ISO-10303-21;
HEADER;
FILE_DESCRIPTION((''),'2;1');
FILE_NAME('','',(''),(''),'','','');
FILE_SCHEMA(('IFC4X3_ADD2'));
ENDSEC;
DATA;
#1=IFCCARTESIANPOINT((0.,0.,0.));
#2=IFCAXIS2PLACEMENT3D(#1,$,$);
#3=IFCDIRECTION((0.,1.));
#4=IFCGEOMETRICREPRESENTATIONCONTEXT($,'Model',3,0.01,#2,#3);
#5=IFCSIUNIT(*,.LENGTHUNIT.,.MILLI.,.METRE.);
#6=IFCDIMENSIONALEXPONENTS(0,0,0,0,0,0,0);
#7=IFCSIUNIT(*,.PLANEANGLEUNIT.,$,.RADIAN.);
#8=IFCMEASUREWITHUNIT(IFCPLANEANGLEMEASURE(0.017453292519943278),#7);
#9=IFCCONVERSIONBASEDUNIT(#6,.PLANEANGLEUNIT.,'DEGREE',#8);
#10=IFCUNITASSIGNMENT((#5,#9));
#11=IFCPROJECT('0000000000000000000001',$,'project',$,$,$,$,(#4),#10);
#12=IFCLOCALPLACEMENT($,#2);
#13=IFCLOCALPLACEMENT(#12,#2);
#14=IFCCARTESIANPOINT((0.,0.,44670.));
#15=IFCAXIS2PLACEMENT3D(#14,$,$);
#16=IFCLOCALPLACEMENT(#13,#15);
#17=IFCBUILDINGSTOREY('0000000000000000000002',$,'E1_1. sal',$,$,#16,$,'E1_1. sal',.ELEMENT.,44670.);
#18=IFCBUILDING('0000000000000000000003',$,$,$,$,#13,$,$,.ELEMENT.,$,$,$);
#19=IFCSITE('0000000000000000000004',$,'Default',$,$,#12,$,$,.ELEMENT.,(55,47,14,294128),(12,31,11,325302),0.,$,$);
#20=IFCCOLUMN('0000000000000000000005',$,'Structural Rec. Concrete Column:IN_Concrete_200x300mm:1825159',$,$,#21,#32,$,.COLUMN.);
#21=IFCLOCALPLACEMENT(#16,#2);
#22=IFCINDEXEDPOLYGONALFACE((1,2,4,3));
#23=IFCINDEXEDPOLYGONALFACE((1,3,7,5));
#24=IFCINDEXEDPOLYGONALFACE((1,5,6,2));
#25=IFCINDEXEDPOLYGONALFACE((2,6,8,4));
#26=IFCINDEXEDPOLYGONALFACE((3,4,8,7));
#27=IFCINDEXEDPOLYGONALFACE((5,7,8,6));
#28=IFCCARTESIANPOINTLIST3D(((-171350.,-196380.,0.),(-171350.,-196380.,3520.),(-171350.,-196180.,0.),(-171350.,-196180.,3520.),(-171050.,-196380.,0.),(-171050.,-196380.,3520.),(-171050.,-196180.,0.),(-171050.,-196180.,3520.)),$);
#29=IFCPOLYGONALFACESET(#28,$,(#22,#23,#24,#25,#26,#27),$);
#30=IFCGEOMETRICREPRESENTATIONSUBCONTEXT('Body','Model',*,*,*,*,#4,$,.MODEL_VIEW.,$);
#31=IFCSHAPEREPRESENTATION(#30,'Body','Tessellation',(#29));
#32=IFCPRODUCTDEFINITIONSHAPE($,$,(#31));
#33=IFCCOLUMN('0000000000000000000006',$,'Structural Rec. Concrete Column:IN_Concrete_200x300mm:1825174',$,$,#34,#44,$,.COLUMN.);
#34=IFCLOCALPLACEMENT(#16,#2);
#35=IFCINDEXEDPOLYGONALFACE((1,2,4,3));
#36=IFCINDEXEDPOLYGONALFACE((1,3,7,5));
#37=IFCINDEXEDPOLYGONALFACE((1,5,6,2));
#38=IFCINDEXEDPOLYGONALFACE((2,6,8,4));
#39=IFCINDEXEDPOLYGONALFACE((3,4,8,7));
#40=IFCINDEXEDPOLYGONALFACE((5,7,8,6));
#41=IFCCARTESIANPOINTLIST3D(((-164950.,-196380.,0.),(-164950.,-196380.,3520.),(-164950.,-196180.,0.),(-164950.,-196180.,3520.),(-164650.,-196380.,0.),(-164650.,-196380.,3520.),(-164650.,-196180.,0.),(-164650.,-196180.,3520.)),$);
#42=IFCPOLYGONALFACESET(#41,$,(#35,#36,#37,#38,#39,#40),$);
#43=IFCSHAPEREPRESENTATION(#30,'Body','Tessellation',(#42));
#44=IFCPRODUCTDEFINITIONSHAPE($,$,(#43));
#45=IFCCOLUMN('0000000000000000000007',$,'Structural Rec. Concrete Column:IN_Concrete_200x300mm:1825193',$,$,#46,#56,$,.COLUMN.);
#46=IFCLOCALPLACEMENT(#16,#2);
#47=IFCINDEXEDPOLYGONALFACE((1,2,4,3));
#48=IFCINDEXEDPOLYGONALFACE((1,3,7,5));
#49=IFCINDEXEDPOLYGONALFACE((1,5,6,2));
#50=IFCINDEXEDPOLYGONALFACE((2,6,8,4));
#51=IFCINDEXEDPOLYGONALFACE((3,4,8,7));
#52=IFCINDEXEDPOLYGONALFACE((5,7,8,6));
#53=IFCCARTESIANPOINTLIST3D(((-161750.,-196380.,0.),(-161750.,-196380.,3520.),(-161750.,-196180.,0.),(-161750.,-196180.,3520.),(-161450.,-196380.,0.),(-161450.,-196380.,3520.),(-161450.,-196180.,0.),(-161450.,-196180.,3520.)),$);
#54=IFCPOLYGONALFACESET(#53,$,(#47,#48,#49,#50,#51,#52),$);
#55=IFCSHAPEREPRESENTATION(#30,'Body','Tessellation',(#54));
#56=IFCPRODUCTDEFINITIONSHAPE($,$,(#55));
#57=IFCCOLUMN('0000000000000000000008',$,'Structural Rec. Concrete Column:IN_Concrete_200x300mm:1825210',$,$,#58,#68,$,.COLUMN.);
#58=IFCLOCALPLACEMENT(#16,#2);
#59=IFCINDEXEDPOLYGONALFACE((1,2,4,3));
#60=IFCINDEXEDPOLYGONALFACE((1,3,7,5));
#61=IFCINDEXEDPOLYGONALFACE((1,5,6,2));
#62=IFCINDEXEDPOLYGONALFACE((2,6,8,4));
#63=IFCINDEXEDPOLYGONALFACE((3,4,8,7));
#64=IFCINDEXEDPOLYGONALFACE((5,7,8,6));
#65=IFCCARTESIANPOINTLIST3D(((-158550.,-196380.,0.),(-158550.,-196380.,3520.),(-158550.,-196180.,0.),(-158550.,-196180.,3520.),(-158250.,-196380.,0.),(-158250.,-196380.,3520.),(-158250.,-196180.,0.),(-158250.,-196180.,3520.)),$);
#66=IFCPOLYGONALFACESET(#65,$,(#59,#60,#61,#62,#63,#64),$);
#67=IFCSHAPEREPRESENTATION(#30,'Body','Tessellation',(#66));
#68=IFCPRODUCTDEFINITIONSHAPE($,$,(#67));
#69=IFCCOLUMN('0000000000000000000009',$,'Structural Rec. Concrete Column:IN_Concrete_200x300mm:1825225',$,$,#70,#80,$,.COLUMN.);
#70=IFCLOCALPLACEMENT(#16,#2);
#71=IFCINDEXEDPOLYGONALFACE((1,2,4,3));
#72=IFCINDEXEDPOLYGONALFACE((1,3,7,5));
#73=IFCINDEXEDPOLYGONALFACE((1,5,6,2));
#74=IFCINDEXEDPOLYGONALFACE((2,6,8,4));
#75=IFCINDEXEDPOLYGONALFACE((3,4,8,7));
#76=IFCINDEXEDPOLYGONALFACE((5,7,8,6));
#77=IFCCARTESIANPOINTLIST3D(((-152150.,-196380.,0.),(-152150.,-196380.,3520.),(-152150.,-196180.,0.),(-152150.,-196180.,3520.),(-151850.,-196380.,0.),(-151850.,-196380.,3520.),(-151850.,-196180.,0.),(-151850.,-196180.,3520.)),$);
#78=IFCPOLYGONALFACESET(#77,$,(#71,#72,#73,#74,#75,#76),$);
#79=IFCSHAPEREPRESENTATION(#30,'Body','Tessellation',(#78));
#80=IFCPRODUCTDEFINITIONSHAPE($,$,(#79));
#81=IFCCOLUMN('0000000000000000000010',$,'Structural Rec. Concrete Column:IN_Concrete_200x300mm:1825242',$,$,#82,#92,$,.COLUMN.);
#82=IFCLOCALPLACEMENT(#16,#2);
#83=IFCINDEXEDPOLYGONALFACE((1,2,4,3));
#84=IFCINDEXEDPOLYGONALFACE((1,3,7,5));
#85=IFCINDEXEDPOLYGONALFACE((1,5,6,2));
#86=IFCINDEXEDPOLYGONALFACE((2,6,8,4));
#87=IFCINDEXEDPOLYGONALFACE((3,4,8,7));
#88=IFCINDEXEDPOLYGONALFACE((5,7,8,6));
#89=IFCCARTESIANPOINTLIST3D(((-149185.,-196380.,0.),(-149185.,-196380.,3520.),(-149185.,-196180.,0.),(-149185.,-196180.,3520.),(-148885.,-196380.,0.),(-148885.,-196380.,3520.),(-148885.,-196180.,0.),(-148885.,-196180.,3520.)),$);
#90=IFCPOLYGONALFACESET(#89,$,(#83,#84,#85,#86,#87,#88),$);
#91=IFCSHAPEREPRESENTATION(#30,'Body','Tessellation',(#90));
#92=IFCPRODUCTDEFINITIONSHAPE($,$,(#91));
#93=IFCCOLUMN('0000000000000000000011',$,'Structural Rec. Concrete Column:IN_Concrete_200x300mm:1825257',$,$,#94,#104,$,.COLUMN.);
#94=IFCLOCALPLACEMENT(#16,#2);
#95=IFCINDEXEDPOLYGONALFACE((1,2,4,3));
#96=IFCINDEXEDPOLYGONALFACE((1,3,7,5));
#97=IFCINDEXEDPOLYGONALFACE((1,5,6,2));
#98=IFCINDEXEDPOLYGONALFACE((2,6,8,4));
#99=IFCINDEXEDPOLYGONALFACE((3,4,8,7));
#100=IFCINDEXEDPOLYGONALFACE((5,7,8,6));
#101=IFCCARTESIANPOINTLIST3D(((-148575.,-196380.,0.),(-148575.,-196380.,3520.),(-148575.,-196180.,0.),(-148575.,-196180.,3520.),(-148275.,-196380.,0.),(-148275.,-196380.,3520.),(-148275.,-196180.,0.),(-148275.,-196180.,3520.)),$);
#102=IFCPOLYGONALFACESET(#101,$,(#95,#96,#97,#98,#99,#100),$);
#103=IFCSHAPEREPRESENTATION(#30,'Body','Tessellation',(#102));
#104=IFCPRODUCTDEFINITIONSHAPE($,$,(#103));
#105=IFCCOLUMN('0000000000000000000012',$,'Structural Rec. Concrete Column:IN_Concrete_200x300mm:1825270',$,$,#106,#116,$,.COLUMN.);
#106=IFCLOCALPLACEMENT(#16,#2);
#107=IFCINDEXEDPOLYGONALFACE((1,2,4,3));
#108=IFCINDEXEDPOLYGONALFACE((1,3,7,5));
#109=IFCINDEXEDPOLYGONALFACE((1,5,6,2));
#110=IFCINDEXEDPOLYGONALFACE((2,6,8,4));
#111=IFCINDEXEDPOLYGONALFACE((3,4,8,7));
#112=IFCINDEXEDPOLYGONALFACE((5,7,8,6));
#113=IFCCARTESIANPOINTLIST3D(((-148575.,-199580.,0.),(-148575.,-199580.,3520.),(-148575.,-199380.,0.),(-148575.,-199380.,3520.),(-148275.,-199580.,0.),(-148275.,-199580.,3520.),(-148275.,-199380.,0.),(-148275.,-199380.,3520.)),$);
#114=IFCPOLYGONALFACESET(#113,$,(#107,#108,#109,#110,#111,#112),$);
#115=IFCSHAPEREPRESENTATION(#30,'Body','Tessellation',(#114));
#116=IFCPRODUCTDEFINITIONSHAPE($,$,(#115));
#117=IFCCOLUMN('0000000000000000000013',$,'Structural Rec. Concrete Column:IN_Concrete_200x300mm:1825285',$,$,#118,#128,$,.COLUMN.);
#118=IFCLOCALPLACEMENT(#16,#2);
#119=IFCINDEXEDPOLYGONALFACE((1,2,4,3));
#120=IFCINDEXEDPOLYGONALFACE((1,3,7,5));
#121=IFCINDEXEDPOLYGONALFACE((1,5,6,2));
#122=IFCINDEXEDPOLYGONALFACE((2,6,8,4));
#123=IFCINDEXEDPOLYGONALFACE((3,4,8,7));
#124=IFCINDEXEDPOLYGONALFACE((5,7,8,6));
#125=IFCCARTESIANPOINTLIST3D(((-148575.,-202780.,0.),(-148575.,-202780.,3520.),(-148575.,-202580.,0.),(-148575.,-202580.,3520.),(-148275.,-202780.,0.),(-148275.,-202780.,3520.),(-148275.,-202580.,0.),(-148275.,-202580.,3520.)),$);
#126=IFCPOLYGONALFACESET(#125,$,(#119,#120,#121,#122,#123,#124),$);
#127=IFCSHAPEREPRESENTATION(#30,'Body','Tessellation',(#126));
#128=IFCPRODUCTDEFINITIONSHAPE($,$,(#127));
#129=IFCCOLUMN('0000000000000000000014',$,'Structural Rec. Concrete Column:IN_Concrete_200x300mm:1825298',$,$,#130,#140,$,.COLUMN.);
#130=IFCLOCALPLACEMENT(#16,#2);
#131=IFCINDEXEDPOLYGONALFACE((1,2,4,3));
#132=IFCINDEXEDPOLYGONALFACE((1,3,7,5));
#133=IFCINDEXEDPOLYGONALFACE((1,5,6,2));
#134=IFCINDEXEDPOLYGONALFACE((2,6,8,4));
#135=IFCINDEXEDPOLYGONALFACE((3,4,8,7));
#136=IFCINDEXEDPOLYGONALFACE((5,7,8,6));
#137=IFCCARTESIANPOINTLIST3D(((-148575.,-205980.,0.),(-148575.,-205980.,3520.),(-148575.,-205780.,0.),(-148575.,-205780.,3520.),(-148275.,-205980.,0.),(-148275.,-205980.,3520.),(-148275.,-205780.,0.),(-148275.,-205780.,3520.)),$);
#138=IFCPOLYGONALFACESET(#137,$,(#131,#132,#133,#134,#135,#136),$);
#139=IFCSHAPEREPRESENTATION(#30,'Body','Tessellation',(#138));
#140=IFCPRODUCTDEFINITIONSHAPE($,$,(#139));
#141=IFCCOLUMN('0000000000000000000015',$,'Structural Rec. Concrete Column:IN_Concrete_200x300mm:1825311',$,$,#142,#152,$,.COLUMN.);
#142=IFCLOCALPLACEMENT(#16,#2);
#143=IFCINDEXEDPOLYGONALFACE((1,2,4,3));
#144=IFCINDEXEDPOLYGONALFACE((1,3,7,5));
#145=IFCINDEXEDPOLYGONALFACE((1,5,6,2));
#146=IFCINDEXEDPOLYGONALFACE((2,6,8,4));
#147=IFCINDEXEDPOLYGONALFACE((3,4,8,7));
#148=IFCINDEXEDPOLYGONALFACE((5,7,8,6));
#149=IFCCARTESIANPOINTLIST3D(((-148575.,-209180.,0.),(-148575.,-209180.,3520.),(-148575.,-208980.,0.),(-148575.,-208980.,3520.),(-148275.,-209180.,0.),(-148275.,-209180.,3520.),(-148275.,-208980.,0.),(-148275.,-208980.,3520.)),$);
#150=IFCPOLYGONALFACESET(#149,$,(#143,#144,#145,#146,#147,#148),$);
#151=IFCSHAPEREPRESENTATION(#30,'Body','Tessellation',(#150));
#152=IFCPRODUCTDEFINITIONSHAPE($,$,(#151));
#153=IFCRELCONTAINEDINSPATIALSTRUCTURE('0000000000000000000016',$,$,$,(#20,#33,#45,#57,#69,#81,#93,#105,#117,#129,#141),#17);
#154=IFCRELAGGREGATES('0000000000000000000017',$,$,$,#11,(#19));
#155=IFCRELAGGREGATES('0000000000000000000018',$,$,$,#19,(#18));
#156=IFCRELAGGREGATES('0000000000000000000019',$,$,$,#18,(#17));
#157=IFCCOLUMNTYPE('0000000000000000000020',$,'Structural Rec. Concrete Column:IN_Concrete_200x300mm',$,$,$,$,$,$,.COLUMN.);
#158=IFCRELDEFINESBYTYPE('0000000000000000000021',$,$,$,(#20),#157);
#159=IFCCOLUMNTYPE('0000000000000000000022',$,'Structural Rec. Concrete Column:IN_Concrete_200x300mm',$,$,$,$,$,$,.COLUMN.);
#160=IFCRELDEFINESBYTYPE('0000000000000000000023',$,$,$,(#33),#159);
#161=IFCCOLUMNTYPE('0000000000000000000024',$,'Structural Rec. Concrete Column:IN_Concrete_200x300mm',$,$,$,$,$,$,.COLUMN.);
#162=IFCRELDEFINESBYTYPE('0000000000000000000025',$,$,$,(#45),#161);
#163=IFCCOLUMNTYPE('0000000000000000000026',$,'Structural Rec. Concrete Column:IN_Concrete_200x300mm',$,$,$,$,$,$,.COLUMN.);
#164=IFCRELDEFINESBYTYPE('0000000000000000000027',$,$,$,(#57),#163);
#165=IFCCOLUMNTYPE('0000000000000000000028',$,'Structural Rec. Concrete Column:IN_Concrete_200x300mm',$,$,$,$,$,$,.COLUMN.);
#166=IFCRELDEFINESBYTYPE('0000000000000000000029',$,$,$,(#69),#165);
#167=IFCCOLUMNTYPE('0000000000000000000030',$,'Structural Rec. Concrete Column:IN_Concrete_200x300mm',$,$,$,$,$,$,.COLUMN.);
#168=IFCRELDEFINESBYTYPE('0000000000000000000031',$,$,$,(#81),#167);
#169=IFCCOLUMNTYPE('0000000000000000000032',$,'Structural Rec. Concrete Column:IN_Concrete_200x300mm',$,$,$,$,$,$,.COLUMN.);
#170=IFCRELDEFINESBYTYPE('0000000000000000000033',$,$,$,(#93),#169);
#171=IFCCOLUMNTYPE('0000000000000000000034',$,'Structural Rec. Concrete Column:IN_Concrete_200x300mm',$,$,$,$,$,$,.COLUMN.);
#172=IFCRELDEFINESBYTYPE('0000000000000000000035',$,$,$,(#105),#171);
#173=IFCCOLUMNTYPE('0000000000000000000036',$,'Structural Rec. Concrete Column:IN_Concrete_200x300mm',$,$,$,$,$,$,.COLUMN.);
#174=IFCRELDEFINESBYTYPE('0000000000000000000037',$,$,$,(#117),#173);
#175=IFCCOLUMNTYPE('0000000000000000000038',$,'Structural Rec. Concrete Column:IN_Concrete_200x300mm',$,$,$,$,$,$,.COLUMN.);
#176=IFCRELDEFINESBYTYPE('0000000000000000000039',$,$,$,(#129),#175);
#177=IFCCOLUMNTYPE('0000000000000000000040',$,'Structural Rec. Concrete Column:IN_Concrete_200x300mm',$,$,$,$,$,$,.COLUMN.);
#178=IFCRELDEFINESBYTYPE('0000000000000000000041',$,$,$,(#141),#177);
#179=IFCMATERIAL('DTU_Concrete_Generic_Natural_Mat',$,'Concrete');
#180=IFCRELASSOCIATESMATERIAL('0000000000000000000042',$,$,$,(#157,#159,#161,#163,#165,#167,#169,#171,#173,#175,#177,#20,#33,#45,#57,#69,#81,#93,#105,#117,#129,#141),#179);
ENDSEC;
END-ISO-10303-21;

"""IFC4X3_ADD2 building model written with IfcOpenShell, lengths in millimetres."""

from ifc_helpers import new_model, entity, si_unit, converted_unit, direction, frame, frame_2d, origin, place, context, subcontext, project, spatial, rectangle, extrude, source, transform, mapped, material, material_profile, profile_set, profile_usage, type_object, type_shapes, element, save


model = new_model("IFC4X3_ADD2")

# Units and contexts
model_context = context("Model", 3, precision=0.01, world=origin(), true_north=direction((0.0, 1.0)))
body_context = subcontext(model_context, "Body", "Model", "MODEL_VIEW")
ifc_project = project(units=[si_unit("LENGTHUNIT", "METRE", prefix="MILLI"), converted_unit("PLANEANGLEUNIT", "DEGREE", entity("IfcPlaneAngleMeasure", 0.017453292519943278), si_unit("PLANEANGLEUNIT", "RADIAN"), dimensions=[0, 0, 0, 0, 0, 0, 0])], contexts=[model_context])

# Site, building, storey
site_placement = place(None, origin())
site = spatial("IfcSite", under=ifc_project, at=site_placement, Name="Default", CompositionType="ELEMENT", RefLatitude=(55, 47, 14, 294128), RefLongitude=(12, 31, 11, 325302), RefElevation=0.0)
building_placement = place(site_placement, origin())
building = spatial("IfcBuilding", under=site, at=building_placement, CompositionType="ELEMENT")
storey_placement = place(building_placement, frame((0.0, 0.0, 44670.0)))
storey = spatial("IfcBuildingStorey", under=building, at=storey_placement, Name="E1_1. sal", LongName="E1_1. sal", CompositionType="ELEMENT", Elevation=44670.0)

# Columns
ifc_material = material(Name="DTU_Concrete_Generic_Natural_Mat", Category="Concrete")
ifc_material_profile_1 = material_profile(ifc_material, rectangle(XDim=200.0, YDim=300.0, at=frame_2d((0.0, 0.0), x_axis=(1.0, 0.0))), Name="IN_Concrete_200x300mm")
ifc_profile_set_1 = profile_set([ifc_material_profile_1], Name="IN_Concrete_200x300mm")
ifc_profile_usage_1 = profile_usage(ifc_profile_set_1)
column_type_1 = type_object("IfcColumnType", Name="Structural Rec. Concrete Column:IN_Concrete_200x300mm", PredefinedType="COLUMN", material=ifc_profile_set_1)
shared_shape_1 = source(origin(), body_context, "Body", "SweptSolid", [
    extrude(rectangle(XDim=200.0, YDim=300.0, at=frame_2d((0.0, 0.0), x_axis=(1.0, 0.0))), frame((-171200.0, -196280.0, 44670.0), z_axis=(0.0, 0.0, 1.0), x_axis=(0.0, -1.0, 0.0)), (0.0, 0.0, 1.0), 3520.0),
])
type_shapes(column_type_1, [shared_shape_1])
column_1_placement = place(storey_placement, frame((0.0, 0.0, -44670.0)))
element("IfcColumn", 1, at=column_1_placement, inside=storey, type_object=column_type_1, material=ifc_profile_usage_1, Name="Structural Rec. Concrete Column:IN_Concrete_200x300mm:1825159", PredefinedType="COLUMN", context=body_context, shape_type="MappedRepresentation", body=[
    mapped(shared_shape_1, transform((0.0, 0.0, 0.0), scale=1.0)),
])
column_type_2 = type_object("IfcColumnType", Name="Structural Rec. Concrete Column:IN_Concrete_200x300mm", PredefinedType="COLUMN", material=ifc_profile_set_1)
shared_shape_2 = source(origin(), body_context, "Body", "SweptSolid", [
    extrude(rectangle(XDim=200.0, YDim=300.0, at=frame_2d((0.0, 0.0), x_axis=(1.0, 0.0))), frame((-164800.0, -196280.0, 44670.0), z_axis=(0.0, 0.0, 1.0), x_axis=(0.0, -1.0, 0.0)), (0.0, 0.0, 1.0), 3520.0),
])
type_shapes(column_type_2, [shared_shape_2])
column_2_placement = place(storey_placement, frame((0.0, 0.0, -44670.0)))
element("IfcColumn", 2, at=column_2_placement, inside=storey, type_object=column_type_2, material=ifc_profile_usage_1, Name="Structural Rec. Concrete Column:IN_Concrete_200x300mm:1825174", PredefinedType="COLUMN", context=body_context, shape_type="MappedRepresentation", body=[
    mapped(shared_shape_2, transform((0.0, 0.0, 0.0), scale=1.0)),
])
column_type_3 = type_object("IfcColumnType", Name="Structural Rec. Concrete Column:IN_Concrete_200x300mm", PredefinedType="COLUMN", material=ifc_profile_set_1)
shared_shape_3 = source(origin(), body_context, "Body", "SweptSolid", [
    extrude(rectangle(XDim=200.0, YDim=300.0, at=frame_2d((0.0, 0.0), x_axis=(1.0, 0.0))), frame((-161600.0, -196280.0, 44670.0), z_axis=(0.0, 0.0, 1.0), x_axis=(0.0, -1.0, 0.0)), (0.0, 0.0, 1.0), 3520.0),
])
type_shapes(column_type_3, [shared_shape_3])
column_3_placement = place(storey_placement, frame((0.0, 0.0, -44670.0)))
element("IfcColumn", 3, at=column_3_placement, inside=storey, type_object=column_type_3, material=ifc_profile_usage_1, Name="Structural Rec. Concrete Column:IN_Concrete_200x300mm:1825193", PredefinedType="COLUMN", context=body_context, shape_type="MappedRepresentation", body=[
    mapped(shared_shape_3, transform((0.0, 0.0, 0.0), scale=1.0)),
])
column_type_4 = type_object("IfcColumnType", Name="Structural Rec. Concrete Column:IN_Concrete_200x300mm", PredefinedType="COLUMN", material=ifc_profile_set_1)
shared_shape_4 = source(origin(), body_context, "Body", "SweptSolid", [
    extrude(rectangle(XDim=200.0, YDim=300.0, at=frame_2d((0.0, 0.0), x_axis=(1.0, 0.0))), frame((-158400.0, -196280.0, 44670.0), z_axis=(0.0, 0.0, 1.0), x_axis=(0.0, -1.0, 0.0)), (0.0, 0.0, 1.0), 3520.0),
])
type_shapes(column_type_4, [shared_shape_4])
column_4_placement = place(storey_placement, frame((0.0, 0.0, -44670.0)))
element("IfcColumn", 4, at=column_4_placement, inside=storey, type_object=column_type_4, material=ifc_profile_usage_1, Name="Structural Rec. Concrete Column:IN_Concrete_200x300mm:1825210", PredefinedType="COLUMN", context=body_context, shape_type="MappedRepresentation", body=[
    mapped(shared_shape_4, transform((0.0, 0.0, 0.0), scale=1.0)),
])
column_type_5 = type_object("IfcColumnType", Name="Structural Rec. Concrete Column:IN_Concrete_200x300mm", PredefinedType="COLUMN", material=ifc_profile_set_1)
shared_shape_5 = source(origin(), body_context, "Body", "SweptSolid", [
    extrude(rectangle(XDim=200.0, YDim=300.0, at=frame_2d((0.0, 0.0), x_axis=(1.0, 0.0))), frame((-152000.0, -196280.0, 44670.0), z_axis=(0.0, 0.0, 1.0), x_axis=(0.0, -1.0, 0.0)), (0.0, 0.0, 1.0), 3520.0),
])
type_shapes(column_type_5, [shared_shape_5])
column_5_placement = place(storey_placement, frame((0.0, 0.0, -44670.0)))
element("IfcColumn", 5, at=column_5_placement, inside=storey, type_object=column_type_5, material=ifc_profile_usage_1, Name="Structural Rec. Concrete Column:IN_Concrete_200x300mm:1825225", PredefinedType="COLUMN", context=body_context, shape_type="MappedRepresentation", body=[
    mapped(shared_shape_5, transform((0.0, 0.0, 0.0), scale=1.0)),
])
column_type_6 = type_object("IfcColumnType", Name="Structural Rec. Concrete Column:IN_Concrete_200x300mm", PredefinedType="COLUMN", material=ifc_profile_set_1)
shared_shape_6 = source(origin(), body_context, "Body", "SweptSolid", [
    extrude(rectangle(XDim=200.0, YDim=300.0, at=frame_2d((0.0, 0.0), x_axis=(1.0, 0.0))), frame((-149035.0, -196280.0, 44670.0), z_axis=(0.0, 0.0, 1.0), x_axis=(0.0, -1.0, 0.0)), (0.0, 0.0, 1.0), 3520.0),
])
type_shapes(column_type_6, [shared_shape_6])
column_6_placement = place(storey_placement, frame((0.0, 0.0, -44670.0)))
element("IfcColumn", 6, at=column_6_placement, inside=storey, type_object=column_type_6, material=ifc_profile_usage_1, Name="Structural Rec. Concrete Column:IN_Concrete_200x300mm:1825242", PredefinedType="COLUMN", context=body_context, shape_type="MappedRepresentation", body=[
    mapped(shared_shape_6, transform((0.0, 0.0, 0.0), scale=1.0)),
])
column_type_7 = type_object("IfcColumnType", Name="Structural Rec. Concrete Column:IN_Concrete_200x300mm", PredefinedType="COLUMN", material=ifc_profile_set_1)
shared_shape_7 = source(origin(), body_context, "Body", "SweptSolid", [
    extrude(rectangle(XDim=200.0, YDim=300.0, at=frame_2d((0.0, 0.0), x_axis=(1.0, 0.0))), frame((-148425.0, -196280.0, 44670.0), z_axis=(0.0, 0.0, 1.0), x_axis=(0.0, -1.0, 0.0)), (0.0, 0.0, 1.0), 3520.0),
])
type_shapes(column_type_7, [shared_shape_7])
column_7_placement = place(storey_placement, frame((0.0, 0.0, -44670.0)))
element("IfcColumn", 7, at=column_7_placement, inside=storey, type_object=column_type_7, material=ifc_profile_usage_1, Name="Structural Rec. Concrete Column:IN_Concrete_200x300mm:1825257", PredefinedType="COLUMN", context=body_context, shape_type="MappedRepresentation", body=[
    mapped(shared_shape_7, transform((0.0, 0.0, 0.0), scale=1.0)),
])
column_type_8 = type_object("IfcColumnType", Name="Structural Rec. Concrete Column:IN_Concrete_200x300mm", PredefinedType="COLUMN", material=ifc_profile_set_1)
shared_shape_8 = source(origin(), body_context, "Body", "SweptSolid", [
    extrude(rectangle(XDim=200.0, YDim=300.0, at=frame_2d((0.0, 0.0), x_axis=(1.0, 0.0))), frame((-148425.0, -199480.0, 44670.0), z_axis=(0.0, 0.0, 1.0), x_axis=(0.0, -1.0, 0.0)), (0.0, 0.0, 1.0), 3520.0),
])
type_shapes(column_type_8, [shared_shape_8])
column_8_placement = place(storey_placement, frame((0.0, 0.0, -44670.0)))
element("IfcColumn", 8, at=column_8_placement, inside=storey, type_object=column_type_8, material=ifc_profile_usage_1, Name="Structural Rec. Concrete Column:IN_Concrete_200x300mm:1825270", PredefinedType="COLUMN", context=body_context, shape_type="MappedRepresentation", body=[
    mapped(shared_shape_8, transform((0.0, 0.0, 0.0), scale=1.0)),
])
column_type_9 = type_object("IfcColumnType", Name="Structural Rec. Concrete Column:IN_Concrete_200x300mm", PredefinedType="COLUMN", material=ifc_profile_set_1)
shared_shape_9 = source(origin(), body_context, "Body", "SweptSolid", [
    extrude(rectangle(XDim=200.0, YDim=300.0, at=frame_2d((0.0, 0.0), x_axis=(1.0, 0.0))), frame((-148425.0, -202680.0, 44670.0), z_axis=(0.0, 0.0, 1.0), x_axis=(0.0, -1.0, 0.0)), (0.0, 0.0, 1.0), 3520.0),
])
type_shapes(column_type_9, [shared_shape_9])
column_9_placement = place(storey_placement, frame((0.0, 0.0, -44670.0)))
element("IfcColumn", 9, at=column_9_placement, inside=storey, type_object=column_type_9, material=ifc_profile_usage_1, Name="Structural Rec. Concrete Column:IN_Concrete_200x300mm:1825285", PredefinedType="COLUMN", context=body_context, shape_type="MappedRepresentation", body=[
    mapped(shared_shape_9, transform((0.0, 0.0, 0.0), scale=1.0)),
])
column_type_10 = type_object("IfcColumnType", Name="Structural Rec. Concrete Column:IN_Concrete_200x300mm", PredefinedType="COLUMN", material=ifc_profile_set_1)
shared_shape_10 = source(origin(), body_context, "Body", "SweptSolid", [
    extrude(rectangle(XDim=200.0, YDim=300.0, at=frame_2d((0.0, 0.0), x_axis=(1.0, 0.0))), frame((-148425.0, -205880.0, 44670.0), z_axis=(0.0, 0.0, 1.0), x_axis=(0.0, -1.0, 0.0)), (0.0, 0.0, 1.0), 3520.0),
])
type_shapes(column_type_10, [shared_shape_10])
column_10_placement = place(storey_placement, frame((0.0, 0.0, -44670.0)))
element("IfcColumn", 10, at=column_10_placement, inside=storey, type_object=column_type_10, material=ifc_profile_usage_1, Name="Structural Rec. Concrete Column:IN_Concrete_200x300mm:1825298", PredefinedType="COLUMN", context=body_context, shape_type="MappedRepresentation", body=[
    mapped(shared_shape_10, transform((0.0, 0.0, 0.0), scale=1.0)),
])
column_type_11 = type_object("IfcColumnType", Name="Structural Rec. Concrete Column:IN_Concrete_200x300mm", PredefinedType="COLUMN", material=ifc_profile_set_1)
shared_shape_11 = source(origin(), body_context, "Body", "SweptSolid", [
    extrude(rectangle(XDim=200.0, YDim=300.0, at=frame_2d((0.0, 0.0), x_axis=(1.0, 0.0))), frame((-148425.0, -209080.0, 44670.0), z_axis=(0.0, 0.0, 1.0), x_axis=(0.0, -1.0, 0.0)), (0.0, 0.0, 1.0), 3520.0),
])
type_shapes(column_type_11, [shared_shape_11])
column_11_placement = place(storey_placement, frame((0.0, 0.0, -44670.0)))
element("IfcColumn", 11, at=column_11_placement, inside=storey, type_object=column_type_11, material=ifc_profile_usage_1, Name="Structural Rec. Concrete Column:IN_Concrete_200x300mm:1825311", PredefinedType="COLUMN", context=body_context, shape_type="MappedRepresentation", body=[
    mapped(shared_shape_11, transform((0.0, 0.0, 0.0), scale=1.0)),
])

save(model, "model.ifc")
